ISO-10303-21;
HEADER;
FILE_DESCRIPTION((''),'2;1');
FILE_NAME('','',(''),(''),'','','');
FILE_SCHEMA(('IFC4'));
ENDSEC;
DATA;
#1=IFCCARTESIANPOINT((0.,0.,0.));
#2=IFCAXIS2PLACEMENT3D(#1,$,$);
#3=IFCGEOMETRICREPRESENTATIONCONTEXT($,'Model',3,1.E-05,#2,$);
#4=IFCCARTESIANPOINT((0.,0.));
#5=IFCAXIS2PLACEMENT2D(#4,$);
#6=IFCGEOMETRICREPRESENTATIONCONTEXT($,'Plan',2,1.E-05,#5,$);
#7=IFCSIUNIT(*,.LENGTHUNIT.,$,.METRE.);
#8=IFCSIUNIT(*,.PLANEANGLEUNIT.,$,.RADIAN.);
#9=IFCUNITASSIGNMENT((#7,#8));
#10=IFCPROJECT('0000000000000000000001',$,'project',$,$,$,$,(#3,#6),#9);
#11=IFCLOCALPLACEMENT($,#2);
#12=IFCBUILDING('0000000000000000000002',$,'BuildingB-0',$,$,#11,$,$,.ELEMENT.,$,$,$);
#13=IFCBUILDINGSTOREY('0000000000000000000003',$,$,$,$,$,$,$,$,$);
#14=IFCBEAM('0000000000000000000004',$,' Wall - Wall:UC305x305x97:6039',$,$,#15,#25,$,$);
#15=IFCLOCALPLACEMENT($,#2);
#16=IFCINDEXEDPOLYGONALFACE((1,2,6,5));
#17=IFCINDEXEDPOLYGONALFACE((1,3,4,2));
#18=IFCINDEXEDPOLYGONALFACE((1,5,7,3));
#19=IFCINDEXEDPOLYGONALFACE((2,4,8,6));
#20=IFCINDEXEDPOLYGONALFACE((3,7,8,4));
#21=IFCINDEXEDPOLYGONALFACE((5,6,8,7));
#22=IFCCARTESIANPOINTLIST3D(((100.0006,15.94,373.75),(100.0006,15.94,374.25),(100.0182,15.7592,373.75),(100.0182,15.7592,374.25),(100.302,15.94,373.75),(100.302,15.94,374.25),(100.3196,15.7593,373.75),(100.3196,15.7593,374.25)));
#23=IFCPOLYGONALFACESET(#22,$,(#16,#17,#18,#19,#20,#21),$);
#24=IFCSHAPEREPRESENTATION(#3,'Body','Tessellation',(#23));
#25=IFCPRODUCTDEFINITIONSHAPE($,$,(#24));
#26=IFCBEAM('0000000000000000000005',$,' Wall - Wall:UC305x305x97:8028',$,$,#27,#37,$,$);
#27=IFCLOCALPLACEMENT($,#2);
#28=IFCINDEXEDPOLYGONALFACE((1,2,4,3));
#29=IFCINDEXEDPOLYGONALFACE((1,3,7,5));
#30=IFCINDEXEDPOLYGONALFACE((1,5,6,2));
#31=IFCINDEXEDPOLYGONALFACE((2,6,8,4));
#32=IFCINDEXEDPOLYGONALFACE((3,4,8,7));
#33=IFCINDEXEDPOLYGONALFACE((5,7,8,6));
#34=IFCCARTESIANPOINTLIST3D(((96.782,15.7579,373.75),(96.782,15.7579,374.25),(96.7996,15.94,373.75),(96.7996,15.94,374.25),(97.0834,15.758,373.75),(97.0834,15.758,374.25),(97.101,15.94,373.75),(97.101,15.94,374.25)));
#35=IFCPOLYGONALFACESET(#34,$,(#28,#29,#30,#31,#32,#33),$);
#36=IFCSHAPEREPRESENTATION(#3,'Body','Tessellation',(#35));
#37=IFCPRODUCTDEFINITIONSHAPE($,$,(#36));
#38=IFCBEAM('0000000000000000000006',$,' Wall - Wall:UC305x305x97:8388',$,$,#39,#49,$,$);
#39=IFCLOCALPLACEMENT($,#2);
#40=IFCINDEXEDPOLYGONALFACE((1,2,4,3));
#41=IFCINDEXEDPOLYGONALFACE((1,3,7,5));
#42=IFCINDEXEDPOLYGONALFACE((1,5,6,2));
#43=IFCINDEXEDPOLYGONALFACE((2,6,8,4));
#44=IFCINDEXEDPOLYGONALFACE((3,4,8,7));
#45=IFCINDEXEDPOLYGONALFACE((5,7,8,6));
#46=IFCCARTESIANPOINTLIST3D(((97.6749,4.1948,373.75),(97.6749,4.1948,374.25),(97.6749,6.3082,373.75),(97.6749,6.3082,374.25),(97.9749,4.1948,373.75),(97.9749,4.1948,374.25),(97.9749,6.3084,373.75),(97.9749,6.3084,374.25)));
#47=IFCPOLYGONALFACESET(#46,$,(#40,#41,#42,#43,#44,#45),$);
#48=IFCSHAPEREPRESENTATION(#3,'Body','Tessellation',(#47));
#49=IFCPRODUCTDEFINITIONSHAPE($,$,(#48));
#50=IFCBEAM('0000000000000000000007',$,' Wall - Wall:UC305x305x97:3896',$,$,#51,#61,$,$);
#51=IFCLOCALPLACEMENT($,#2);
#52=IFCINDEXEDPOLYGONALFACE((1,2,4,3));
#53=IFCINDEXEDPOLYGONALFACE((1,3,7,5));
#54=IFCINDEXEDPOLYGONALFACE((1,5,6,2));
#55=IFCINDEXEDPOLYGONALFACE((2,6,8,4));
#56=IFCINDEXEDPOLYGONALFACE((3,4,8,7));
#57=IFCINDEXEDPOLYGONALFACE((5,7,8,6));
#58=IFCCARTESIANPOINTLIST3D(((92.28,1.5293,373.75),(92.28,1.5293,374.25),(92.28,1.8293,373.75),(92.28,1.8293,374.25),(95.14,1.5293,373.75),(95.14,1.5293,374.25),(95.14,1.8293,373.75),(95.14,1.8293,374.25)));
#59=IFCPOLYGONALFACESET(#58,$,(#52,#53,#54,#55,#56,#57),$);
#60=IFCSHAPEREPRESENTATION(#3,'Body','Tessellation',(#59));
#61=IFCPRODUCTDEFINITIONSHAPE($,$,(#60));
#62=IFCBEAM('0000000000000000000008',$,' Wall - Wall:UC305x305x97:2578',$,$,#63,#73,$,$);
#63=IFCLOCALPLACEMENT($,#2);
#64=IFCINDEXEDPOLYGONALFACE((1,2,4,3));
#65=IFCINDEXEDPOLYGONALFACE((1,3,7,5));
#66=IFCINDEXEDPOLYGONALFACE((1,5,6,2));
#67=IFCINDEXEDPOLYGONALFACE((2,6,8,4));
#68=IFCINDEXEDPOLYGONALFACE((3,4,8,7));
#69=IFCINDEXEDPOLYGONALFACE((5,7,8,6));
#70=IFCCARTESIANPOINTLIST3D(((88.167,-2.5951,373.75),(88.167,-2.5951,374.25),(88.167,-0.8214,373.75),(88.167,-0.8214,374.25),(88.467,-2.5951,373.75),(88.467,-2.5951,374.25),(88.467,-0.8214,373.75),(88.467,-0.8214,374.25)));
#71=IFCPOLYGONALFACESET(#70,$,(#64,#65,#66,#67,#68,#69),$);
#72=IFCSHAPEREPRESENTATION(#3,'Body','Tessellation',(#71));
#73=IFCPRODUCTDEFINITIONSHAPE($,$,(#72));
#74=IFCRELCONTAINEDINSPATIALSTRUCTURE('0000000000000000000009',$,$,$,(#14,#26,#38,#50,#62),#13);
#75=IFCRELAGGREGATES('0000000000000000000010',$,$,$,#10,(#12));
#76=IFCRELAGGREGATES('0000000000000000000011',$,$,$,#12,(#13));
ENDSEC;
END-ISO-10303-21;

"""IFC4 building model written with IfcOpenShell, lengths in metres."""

from ifc_helpers import new_model, si_unit, origin, origin_2d, place, context, project, spatial, polyline, outline, extrude, element, save


model = new_model("IFC4")

# Units and contexts
model_context = context("Model", 3, precision=1e-05, world=origin())
plan_context = context("Plan", 2, precision=1e-05, world=origin_2d())
ifc_project = project(units=[si_unit("LENGTHUNIT", "METRE"), si_unit("PLANEANGLEUNIT", "RADIAN")], contexts=[model_context, plan_context])

# Building, storey
building_placement = place(None, origin())
building = spatial("IfcBuilding", under=ifc_project, at=building_placement, Name="BuildingB-0", CompositionType="ELEMENT")
storey = spatial("IfcBuildingStorey", under=building)

# Beams
element("IfcBeam", 1, inside=storey, Name=" Wall - Wall:UC305x305x97:6039", context=model_context, shape_type="SweptSolid", body=[
    extrude(outline(polyline([(100.3196, 15.7593, 373.75), (100.302, 15.94, 373.75), (100.0006, 15.94, 373.75), (100.0182, 15.7592, 373.75), (100.3196, 15.7593, 373.75)])), None, (0.0, 0.0, 1.0), 0.5),
])
element("IfcBeam", 2, inside=storey, Name=" Wall - Wall:UC305x305x97:8028", context=model_context, shape_type="SweptSolid", body=[
    extrude(outline(polyline([(97.0834, 15.758, 373.75), (97.101, 15.94, 373.75), (96.7996, 15.94, 373.75), (96.782, 15.7579, 373.75), (97.0834, 15.758, 373.75)])), None, (0.0, 0.0, 1.0), 0.5),
])
element("IfcBeam", 3, inside=storey, Name=" Wall - Wall:UC305x305x97:8388", context=model_context, shape_type="SweptSolid", body=[
    extrude(outline(polyline([(97.9749, 4.1948, 373.75), (97.9749, 6.3084, 373.75), (97.6749, 6.3082, 373.75), (97.6749, 4.1948, 373.75), (97.9749, 4.1948, 373.75)])), None, (0.0, 0.0, 1.0), 0.5),
])
element("IfcBeam", 4, inside=storey, Name=" Wall - Wall:UC305x305x97:3896", context=model_context, shape_type="SweptSolid", body=[
    extrude(outline(polyline([(95.14, 1.5293, 373.75), (95.14, 1.8293, 373.75), (92.28, 1.8293, 373.75), (92.28, 1.5293, 373.75), (95.14, 1.5293, 373.75)])), None, (0.0, 0.0, 1.0), 0.5),
])
element("IfcBeam", 5, inside=storey, Name=" Wall - Wall:UC305x305x97:2578", context=model_context, shape_type="SweptSolid", body=[
    extrude(outline(polyline([(88.467, -2.5951, 373.75), (88.467, -0.8214, 373.75), (88.167, -0.8214, 373.75), (88.167, -2.5951, 373.75), (88.467, -2.5951, 373.75)])), None, (0.0, 0.0, 1.0), 0.5),
])

save(model, "model.ifc")
